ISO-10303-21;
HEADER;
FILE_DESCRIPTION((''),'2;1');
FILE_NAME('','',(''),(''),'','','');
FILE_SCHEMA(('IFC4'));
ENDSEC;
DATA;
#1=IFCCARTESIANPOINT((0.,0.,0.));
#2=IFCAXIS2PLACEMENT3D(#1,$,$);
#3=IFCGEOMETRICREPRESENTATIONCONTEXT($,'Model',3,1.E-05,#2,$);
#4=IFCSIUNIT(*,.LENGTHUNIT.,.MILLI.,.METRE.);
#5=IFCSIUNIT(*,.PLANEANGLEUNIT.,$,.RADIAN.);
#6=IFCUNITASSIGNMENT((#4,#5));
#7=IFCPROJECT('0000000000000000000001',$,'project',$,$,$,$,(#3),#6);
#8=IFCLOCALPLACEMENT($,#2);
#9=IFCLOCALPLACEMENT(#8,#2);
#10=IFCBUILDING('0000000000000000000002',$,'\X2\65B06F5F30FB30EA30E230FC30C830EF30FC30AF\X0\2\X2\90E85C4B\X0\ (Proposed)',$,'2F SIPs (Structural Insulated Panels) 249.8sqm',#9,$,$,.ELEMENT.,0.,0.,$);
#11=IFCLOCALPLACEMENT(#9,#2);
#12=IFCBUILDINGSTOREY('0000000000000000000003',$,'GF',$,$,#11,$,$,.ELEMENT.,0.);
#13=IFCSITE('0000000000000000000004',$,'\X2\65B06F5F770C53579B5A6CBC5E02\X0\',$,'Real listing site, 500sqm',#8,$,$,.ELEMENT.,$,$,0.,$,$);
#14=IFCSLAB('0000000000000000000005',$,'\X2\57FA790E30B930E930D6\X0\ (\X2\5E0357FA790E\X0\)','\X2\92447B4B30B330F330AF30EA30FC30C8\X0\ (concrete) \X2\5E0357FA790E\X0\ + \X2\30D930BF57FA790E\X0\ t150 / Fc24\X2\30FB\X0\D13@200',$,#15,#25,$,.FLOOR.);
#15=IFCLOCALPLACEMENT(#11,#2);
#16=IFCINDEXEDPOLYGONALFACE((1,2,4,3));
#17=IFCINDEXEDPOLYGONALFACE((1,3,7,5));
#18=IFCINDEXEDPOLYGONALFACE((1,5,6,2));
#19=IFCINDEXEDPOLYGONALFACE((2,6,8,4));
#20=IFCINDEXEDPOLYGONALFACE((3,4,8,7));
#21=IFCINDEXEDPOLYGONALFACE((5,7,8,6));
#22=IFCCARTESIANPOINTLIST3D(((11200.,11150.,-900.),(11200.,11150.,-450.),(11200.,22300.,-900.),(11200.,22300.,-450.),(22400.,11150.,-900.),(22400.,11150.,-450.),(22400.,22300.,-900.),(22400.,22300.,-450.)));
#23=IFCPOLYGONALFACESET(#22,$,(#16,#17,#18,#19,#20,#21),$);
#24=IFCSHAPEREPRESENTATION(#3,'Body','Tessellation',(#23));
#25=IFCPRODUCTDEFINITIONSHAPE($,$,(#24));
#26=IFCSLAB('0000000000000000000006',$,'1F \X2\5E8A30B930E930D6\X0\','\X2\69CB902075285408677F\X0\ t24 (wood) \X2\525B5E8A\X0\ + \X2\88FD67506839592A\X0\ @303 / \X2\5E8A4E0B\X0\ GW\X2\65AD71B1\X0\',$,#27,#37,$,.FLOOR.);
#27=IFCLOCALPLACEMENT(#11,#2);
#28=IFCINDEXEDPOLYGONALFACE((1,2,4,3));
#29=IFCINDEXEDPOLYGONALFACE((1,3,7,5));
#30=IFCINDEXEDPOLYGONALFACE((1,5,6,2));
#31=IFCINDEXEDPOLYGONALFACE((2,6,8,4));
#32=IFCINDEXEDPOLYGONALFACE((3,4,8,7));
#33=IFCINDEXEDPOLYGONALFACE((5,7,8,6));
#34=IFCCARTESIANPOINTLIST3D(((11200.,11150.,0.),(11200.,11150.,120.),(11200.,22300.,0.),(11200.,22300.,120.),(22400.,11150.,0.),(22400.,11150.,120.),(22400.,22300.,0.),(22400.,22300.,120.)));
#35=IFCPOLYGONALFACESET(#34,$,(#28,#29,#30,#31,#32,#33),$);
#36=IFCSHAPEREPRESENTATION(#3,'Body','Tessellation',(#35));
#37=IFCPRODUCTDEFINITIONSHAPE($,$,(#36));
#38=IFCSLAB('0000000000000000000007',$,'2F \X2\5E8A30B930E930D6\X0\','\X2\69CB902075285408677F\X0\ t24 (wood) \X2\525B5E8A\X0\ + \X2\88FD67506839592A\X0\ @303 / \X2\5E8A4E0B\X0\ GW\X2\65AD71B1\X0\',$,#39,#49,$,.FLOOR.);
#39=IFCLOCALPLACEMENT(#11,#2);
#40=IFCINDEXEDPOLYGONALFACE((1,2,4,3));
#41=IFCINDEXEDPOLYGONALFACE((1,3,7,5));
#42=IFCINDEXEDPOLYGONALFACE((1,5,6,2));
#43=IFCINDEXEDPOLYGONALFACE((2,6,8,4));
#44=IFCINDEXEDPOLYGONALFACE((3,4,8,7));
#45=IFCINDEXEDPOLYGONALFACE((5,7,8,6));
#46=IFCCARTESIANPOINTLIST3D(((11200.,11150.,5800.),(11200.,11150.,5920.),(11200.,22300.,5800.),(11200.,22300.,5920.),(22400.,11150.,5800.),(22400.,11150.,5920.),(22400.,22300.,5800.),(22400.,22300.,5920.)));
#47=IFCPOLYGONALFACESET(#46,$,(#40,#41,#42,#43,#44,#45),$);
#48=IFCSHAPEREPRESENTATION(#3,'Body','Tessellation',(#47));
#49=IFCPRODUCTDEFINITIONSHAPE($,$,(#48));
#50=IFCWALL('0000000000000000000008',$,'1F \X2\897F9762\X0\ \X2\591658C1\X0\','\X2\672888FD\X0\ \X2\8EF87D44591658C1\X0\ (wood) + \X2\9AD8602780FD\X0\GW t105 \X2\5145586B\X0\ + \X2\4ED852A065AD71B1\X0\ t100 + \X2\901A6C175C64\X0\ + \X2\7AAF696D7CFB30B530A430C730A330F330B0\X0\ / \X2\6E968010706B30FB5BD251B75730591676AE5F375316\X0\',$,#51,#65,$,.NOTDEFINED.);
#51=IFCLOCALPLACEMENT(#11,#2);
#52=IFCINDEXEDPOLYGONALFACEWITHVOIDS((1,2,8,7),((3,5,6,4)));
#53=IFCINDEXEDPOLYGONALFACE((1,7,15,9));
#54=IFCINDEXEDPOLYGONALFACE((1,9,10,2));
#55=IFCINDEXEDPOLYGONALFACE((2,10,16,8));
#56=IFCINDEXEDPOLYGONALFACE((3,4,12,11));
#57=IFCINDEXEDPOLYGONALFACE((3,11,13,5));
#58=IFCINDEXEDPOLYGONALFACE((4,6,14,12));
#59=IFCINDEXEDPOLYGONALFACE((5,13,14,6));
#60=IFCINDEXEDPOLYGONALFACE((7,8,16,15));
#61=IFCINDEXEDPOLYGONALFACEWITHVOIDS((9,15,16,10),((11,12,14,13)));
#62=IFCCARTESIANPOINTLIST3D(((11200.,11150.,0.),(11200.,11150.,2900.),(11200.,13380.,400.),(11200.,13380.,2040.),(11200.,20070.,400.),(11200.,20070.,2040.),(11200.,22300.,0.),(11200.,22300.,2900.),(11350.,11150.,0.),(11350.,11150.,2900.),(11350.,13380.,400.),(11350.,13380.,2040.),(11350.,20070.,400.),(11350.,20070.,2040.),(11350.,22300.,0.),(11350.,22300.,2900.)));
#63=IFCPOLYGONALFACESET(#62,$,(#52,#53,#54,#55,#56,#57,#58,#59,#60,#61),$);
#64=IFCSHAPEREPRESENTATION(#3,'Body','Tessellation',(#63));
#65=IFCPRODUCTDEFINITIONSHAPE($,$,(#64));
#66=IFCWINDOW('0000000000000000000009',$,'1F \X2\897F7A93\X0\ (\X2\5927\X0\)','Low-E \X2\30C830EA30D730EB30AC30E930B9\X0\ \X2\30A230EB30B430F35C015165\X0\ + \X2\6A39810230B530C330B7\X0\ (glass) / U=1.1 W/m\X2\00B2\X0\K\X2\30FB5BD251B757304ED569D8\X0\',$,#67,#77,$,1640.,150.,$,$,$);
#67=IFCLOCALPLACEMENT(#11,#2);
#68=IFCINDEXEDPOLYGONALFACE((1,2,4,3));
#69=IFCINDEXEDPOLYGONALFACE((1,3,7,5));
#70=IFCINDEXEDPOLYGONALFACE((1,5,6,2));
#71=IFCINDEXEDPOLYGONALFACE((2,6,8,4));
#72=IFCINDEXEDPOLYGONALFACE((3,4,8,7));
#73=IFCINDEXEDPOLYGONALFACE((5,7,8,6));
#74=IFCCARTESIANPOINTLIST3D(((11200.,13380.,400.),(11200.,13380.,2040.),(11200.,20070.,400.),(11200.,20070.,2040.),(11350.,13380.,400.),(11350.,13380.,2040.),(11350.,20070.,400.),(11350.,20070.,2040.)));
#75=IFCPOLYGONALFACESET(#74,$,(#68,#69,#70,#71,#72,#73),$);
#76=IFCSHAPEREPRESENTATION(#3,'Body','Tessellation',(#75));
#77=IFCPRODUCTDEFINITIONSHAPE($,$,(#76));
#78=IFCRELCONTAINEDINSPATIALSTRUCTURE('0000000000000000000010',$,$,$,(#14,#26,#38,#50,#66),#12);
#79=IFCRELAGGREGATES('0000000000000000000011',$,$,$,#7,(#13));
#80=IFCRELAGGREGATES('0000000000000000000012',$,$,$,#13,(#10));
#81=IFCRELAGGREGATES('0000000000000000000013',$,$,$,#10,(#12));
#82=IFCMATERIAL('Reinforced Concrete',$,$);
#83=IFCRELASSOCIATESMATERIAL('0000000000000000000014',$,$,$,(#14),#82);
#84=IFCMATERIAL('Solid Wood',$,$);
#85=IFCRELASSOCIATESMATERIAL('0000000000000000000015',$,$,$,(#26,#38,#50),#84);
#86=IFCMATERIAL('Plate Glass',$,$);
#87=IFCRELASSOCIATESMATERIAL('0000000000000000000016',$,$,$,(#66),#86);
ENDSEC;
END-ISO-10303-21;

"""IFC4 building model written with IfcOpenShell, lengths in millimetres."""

from ifc_helpers import new_model, si_unit, frame, frame_2d, origin, place, context, project, spatial, rectangle, extrude, material, element, fill, save


model = new_model("IFC4")

# Units and contexts
model_context = context("Model", 3, precision=1e-05, world=origin())
ifc_project = project(units=[si_unit("LENGTHUNIT", "METRE", prefix="MILLI"), si_unit("PLANEANGLEUNIT", "RADIAN")], contexts=[model_context])

# Site, building, storey
site_placement = place(None, origin())
site = spatial("IfcSite", under=ifc_project, at=site_placement, Name="新潟県南魚沼市", ObjectType="Real listing site, 500sqm", CompositionType="ELEMENT", RefElevation=0.0)
building_placement = place(site_placement, origin())
building = spatial("IfcBuilding", under=site, at=building_placement, Name="新潟・リモートワーク2部屋 (Proposed)", ObjectType="2F SIPs (Structural Insulated Panels) 249.8sqm", CompositionType="ELEMENT", ElevationOfRefHeight=0.0, ElevationOfTerrain=0.0)
storey_placement = place(building_placement, origin())
storey = spatial("IfcBuildingStorey", under=building, at=storey_placement, Name="GF", CompositionType="ELEMENT", Elevation=0.0)

# Shared definitions
ifc_material_1 = material(Name="Solid Wood")

# Slabs
ifc_material_2 = material(Name="Reinforced Concrete")
slab_1_placement = place(storey_placement, frame((5600.0, 5575.0, -450.0)))
element("IfcSlab", 1, at=slab_1_placement, inside=storey, material=ifc_material_2, Name="基礎スラブ (布基礎)", Description="鉄筋コンクリート (concrete) 布基礎 + ベタ基礎 t150 / Fc24・D13@200", PredefinedType="FLOOR", context=model_context, shape_type="SweptSolid", body=[
    extrude(rectangle(XDim=11200.0, YDim=11150.0, at=frame_2d((5600.0, 5575.0))), frame((5600.0, 5575.0, -450.0)), (0.0, 0.0, 1.0), 450.0),
])
slab_2_placement = place(storey_placement, frame((5600.0, 5575.0, 0.0)))
element("IfcSlab", 2, at=slab_2_placement, inside=storey, material=ifc_material_1, Name="1F 床スラブ", Description="構造用合板 t24 (wood) 剛床 + 製材根太 @303 / 床下 GW断熱", PredefinedType="FLOOR", context=model_context, shape_type="SweptSolid", body=[
    extrude(rectangle(XDim=11200.0, YDim=11150.0, at=frame_2d((5600.0, 5575.0))), frame((5600.0, 5575.0, 0.0)), (0.0, 0.0, 1.0), 120.0),
])
slab_3_placement = place(storey_placement, frame((5600.0, 5575.0, 2900.0)))
element("IfcSlab", 3, at=slab_3_placement, inside=storey, material=ifc_material_1, Name="2F 床スラブ", Description="構造用合板 t24 (wood) 剛床 + 製材根太 @303 / 床下 GW断熱", PredefinedType="FLOOR", context=model_context, shape_type="SweptSolid", body=[
    extrude(rectangle(XDim=11200.0, YDim=11150.0, at=frame_2d((5600.0, 5575.0))), frame((5600.0, 5575.0, 2900.0)), (0.0, 0.0, 1.0), 120.0),
])

# Shared definitions
ifc_material_3 = material(Name="Plate Glass")

# Wall, opening, window
wall_1_placement = place(storey_placement, frame((5600.0, 5575.0, 0.0)))
wall_1 = element("IfcWall", 4, at=wall_1_placement, inside=storey, material=ifc_material_1, Name="1F 西面 外壁", Description="木製 軸組外壁 (wood) + 高性能GW t105 充填 + 付加断熱 t100 + 通気層 + 窯業系サイディング / 準耐火・寒冷地外皮強化", PredefinedType="NOTDEFINED", context=model_context, shape_type="SweptSolid", body=[
    extrude(rectangle(XDim=150.0, YDim=11150.0, at=frame_2d((75.0, 5575.0))), frame((5600.0, 5575.0, 0.0)), (0.0, 0.0, 1.0), 2900.0),
])
opening_1_placement = place(storey_placement, frame((5600.0, 6690.0, 200.0)))
opening_1 = element("IfcOpeningElement", 5, at=opening_1_placement, cuts=wall_1, PredefinedType="NOTDEFINED", context=model_context, shape_type="SweptSolid", body=[
    extrude(rectangle(XDim=150.0, YDim=6690.0, at=frame_2d((75.0, 3345.0))), frame((5600.0, 6690.0, 200.0)), (0.0, 0.0, 1.0), 1640.0),
])
window_1_placement = place(storey_placement, frame((5600.0, 6690.0, 200.0)))
window_1 = element("IfcWindow", 6, at=window_1_placement, inside=storey, material=ifc_material_3, Name="1F 西窓 (大)", Description="Low-E トリプルガラス アルゴン封入 + 樹脂サッシ (glass) / U=1.1 W/m²K・寒冷地仕様", OverallHeight=1640.0, OverallWidth=150.0, context=model_context, shape_type="SweptSolid", body=[
    extrude(rectangle(XDim=150.0, YDim=6690.0, at=frame_2d((75.0, 3345.0))), frame((5600.0, 6690.0, 200.0)), (0.0, 0.0, 1.0), 1640.0),
])
fill(opening_1, window_1)

save(model, "model.ifc")
